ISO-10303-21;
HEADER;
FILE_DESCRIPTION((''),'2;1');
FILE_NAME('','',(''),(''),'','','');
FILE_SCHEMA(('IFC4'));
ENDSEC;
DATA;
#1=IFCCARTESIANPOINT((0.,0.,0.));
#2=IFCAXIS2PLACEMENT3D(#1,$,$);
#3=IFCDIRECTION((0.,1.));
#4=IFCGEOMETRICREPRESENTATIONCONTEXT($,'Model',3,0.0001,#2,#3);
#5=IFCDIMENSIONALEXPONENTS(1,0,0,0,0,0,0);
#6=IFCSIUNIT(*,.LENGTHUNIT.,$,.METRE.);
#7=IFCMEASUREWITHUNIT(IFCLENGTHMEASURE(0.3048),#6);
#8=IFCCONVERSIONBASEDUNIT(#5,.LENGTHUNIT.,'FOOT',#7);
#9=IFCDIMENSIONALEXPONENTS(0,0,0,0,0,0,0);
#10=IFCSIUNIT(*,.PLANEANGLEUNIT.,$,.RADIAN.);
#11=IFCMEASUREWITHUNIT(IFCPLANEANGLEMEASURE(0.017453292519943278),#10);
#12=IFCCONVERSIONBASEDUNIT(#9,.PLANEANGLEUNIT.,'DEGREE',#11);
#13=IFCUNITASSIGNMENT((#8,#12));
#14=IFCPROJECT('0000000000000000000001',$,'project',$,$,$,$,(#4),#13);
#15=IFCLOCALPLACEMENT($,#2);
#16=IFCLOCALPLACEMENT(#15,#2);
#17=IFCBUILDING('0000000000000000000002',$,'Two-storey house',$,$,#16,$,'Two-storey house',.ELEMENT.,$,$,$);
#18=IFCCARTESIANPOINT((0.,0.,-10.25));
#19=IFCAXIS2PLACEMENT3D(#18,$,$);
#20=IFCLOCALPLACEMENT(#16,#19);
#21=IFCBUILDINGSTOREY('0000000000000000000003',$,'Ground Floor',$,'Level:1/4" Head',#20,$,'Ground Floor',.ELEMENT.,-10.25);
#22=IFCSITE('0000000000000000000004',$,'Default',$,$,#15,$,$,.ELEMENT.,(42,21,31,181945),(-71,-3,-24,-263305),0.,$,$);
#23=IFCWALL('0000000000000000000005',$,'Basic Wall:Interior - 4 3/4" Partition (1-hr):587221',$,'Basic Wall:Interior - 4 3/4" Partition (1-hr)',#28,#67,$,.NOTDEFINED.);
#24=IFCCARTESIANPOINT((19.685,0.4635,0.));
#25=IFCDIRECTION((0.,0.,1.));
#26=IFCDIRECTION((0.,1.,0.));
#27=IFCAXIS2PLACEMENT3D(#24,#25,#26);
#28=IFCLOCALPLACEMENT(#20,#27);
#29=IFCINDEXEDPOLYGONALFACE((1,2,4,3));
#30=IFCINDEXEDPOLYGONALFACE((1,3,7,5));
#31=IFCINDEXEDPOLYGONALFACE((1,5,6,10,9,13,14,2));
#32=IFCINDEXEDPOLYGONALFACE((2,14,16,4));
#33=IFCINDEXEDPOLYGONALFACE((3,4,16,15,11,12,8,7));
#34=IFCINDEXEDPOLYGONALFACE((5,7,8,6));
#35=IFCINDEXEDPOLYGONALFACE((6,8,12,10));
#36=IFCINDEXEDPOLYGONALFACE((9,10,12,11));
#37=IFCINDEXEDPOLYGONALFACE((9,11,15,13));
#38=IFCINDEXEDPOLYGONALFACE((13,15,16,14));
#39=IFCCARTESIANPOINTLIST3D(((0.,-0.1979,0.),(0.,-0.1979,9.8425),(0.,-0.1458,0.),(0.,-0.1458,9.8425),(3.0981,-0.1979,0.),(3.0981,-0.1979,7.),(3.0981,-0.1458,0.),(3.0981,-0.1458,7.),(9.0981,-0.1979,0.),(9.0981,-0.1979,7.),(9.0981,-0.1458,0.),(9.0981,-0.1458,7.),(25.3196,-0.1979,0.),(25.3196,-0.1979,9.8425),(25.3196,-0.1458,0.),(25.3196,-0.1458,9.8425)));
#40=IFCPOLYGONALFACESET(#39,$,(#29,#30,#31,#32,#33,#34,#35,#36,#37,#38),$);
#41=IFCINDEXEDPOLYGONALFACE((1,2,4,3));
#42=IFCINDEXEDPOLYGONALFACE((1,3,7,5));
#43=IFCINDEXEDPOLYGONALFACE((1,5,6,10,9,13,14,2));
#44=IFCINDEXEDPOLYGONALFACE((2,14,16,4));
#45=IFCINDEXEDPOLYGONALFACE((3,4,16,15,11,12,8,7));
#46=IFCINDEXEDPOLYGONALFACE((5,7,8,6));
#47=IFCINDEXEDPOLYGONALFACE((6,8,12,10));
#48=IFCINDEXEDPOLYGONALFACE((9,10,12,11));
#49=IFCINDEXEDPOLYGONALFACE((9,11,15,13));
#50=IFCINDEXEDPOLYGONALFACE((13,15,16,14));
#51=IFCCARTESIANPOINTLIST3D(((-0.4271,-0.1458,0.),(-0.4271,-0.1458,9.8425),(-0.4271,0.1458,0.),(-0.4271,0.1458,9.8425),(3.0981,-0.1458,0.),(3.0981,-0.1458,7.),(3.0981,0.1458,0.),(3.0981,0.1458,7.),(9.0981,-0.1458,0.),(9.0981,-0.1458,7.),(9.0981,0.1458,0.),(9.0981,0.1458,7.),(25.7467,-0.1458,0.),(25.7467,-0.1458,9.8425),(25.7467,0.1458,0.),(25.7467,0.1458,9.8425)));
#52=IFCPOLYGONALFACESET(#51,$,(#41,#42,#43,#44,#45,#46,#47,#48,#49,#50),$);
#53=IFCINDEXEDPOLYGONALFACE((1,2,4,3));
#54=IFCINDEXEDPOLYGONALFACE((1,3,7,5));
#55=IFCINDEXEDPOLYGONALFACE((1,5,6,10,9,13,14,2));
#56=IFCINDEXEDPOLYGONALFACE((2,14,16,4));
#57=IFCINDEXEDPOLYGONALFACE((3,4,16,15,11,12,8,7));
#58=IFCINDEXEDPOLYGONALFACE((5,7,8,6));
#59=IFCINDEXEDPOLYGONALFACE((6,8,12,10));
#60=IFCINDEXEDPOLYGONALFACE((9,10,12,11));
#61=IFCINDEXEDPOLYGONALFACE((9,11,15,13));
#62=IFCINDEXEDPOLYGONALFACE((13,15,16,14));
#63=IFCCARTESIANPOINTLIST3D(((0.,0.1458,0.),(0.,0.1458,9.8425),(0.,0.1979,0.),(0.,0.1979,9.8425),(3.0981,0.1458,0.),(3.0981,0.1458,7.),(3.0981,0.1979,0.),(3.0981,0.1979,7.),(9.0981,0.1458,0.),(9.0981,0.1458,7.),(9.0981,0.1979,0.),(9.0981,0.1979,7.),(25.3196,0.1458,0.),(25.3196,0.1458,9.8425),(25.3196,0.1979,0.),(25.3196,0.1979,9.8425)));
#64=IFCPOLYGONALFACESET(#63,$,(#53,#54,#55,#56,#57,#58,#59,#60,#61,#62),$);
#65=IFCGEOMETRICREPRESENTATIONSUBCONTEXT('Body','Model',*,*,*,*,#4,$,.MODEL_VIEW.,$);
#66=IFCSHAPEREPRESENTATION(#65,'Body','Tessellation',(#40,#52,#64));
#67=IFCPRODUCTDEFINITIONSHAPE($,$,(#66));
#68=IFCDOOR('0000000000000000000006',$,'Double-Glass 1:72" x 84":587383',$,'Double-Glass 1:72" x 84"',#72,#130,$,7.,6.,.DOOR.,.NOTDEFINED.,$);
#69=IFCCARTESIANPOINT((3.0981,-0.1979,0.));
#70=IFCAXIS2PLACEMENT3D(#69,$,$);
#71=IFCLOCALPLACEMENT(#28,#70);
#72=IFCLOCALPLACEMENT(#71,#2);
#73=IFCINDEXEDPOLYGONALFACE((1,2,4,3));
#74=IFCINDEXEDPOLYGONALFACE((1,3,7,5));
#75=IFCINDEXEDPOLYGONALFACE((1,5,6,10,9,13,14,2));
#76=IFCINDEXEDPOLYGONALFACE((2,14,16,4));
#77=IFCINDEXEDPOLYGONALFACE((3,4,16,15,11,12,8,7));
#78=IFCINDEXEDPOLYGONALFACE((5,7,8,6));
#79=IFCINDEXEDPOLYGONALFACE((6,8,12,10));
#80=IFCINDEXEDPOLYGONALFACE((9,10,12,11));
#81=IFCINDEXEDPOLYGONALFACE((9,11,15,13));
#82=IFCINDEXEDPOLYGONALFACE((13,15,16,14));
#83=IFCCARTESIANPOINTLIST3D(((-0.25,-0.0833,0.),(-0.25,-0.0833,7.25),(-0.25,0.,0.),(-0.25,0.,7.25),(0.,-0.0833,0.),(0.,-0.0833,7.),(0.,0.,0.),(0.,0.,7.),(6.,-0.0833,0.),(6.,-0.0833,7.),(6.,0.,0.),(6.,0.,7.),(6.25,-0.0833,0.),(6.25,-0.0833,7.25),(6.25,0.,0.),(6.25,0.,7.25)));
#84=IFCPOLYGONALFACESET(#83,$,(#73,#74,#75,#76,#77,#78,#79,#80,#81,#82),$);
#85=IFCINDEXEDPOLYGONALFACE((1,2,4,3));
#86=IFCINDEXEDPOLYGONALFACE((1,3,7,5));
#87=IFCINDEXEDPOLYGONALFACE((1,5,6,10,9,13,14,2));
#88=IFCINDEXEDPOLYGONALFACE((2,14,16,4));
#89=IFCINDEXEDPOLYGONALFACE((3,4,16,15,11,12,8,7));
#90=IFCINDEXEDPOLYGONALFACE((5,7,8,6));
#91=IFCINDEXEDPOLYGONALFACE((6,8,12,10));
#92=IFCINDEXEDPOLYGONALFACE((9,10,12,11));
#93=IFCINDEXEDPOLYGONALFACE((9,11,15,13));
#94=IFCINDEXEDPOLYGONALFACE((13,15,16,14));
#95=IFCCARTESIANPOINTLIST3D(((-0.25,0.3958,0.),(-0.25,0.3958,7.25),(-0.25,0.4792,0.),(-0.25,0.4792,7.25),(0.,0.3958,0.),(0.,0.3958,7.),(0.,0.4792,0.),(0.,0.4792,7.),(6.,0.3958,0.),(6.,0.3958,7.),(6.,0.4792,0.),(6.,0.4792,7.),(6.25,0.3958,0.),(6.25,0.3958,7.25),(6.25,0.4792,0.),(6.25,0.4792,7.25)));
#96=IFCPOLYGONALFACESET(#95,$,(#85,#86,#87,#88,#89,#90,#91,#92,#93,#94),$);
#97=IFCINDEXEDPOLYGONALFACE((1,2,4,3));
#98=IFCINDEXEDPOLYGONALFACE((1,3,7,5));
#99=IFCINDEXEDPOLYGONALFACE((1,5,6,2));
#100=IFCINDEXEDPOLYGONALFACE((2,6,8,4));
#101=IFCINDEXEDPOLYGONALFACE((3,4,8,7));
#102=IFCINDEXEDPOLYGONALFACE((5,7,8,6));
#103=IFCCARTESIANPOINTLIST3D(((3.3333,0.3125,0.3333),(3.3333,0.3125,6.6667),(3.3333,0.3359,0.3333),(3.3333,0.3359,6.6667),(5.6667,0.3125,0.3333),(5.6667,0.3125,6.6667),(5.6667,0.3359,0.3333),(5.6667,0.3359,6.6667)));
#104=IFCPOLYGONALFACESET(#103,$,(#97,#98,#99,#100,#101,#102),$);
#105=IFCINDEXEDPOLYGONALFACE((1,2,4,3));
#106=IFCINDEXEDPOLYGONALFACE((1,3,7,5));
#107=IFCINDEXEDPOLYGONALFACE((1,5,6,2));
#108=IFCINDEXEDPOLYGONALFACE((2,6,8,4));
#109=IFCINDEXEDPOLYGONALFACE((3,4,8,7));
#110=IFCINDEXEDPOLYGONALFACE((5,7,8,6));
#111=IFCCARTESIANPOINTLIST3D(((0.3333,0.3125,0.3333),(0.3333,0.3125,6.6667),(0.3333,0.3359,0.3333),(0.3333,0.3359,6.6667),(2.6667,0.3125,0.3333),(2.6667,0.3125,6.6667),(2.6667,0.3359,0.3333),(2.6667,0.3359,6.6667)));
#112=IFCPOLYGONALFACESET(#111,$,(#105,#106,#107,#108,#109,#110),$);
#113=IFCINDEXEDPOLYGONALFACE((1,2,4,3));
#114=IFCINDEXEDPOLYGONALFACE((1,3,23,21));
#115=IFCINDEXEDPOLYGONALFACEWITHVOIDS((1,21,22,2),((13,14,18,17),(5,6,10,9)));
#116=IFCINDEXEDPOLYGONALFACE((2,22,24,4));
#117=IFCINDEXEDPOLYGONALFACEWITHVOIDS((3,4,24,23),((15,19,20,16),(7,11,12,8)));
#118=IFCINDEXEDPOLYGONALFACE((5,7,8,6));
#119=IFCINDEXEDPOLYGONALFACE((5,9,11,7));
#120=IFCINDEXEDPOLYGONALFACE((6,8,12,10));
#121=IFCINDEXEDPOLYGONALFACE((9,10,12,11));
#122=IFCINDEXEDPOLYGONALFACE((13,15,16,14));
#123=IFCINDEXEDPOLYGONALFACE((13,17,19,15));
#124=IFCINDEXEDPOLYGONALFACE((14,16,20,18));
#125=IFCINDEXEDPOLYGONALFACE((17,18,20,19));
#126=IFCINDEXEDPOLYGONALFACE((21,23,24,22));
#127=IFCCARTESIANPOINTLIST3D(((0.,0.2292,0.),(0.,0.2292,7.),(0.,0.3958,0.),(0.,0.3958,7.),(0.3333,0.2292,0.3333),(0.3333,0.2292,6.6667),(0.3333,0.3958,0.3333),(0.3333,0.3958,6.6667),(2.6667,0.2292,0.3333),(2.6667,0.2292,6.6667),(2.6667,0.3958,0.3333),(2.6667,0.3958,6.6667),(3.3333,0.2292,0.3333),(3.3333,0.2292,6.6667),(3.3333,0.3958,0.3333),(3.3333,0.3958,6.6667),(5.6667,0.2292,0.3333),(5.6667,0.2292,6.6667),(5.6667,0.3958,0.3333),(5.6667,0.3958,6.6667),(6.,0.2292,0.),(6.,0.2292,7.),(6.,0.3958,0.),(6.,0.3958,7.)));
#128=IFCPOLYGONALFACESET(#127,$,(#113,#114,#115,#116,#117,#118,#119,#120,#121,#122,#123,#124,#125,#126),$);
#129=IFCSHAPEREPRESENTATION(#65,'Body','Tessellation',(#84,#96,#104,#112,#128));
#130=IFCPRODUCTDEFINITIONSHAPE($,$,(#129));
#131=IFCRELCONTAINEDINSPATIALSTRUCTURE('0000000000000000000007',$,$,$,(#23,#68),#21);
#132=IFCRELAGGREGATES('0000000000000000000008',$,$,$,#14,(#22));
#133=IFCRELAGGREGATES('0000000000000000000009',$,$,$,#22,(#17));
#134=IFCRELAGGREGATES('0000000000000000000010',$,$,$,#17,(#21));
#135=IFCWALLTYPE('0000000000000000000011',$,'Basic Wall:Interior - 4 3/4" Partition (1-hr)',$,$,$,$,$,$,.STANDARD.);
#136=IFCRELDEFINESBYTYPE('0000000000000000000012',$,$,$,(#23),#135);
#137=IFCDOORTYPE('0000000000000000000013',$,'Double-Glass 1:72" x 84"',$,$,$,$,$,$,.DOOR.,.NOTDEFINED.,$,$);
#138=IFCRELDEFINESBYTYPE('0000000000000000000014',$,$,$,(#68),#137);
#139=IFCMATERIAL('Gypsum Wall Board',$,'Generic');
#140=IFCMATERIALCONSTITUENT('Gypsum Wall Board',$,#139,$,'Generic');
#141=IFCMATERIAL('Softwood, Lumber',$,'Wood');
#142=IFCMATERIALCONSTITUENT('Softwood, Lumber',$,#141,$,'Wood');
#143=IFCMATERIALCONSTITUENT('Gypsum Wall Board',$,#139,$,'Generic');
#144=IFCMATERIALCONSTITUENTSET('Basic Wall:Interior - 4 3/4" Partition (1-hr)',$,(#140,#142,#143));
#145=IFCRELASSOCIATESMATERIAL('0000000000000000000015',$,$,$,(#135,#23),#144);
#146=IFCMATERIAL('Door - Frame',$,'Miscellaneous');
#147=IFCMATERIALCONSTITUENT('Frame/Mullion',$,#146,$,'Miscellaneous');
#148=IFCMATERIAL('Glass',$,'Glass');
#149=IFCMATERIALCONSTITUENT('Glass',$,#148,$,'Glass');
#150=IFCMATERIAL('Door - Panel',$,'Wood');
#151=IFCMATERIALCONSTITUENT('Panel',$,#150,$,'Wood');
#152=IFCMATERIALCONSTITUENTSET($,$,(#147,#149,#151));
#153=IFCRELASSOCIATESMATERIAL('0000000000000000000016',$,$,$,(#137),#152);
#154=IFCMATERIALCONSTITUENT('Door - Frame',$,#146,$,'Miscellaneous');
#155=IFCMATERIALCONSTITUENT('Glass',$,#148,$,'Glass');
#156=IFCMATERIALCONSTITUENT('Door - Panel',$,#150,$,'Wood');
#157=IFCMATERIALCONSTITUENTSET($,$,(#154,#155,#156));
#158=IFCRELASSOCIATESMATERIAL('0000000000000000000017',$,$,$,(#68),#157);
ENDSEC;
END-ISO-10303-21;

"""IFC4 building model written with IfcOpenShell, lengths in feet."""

from ifc_helpers import new_model, entity, si_unit, converted_unit, direction, frame, origin, place, context, subcontext, project, spatial, indexed_curve, outline, extrude, source, transform, mapped, material, constituent, constituent_set, type_object, type_shapes, element, fill, save


model = new_model("IFC4")

# Units and contexts
model_context = context("Model", 3, precision=0.0001, world=origin(), true_north=direction((0.0, 1.0)))
body_context = subcontext(model_context, "Body", "Model", "MODEL_VIEW")
ifc_project = project(units=[converted_unit("LENGTHUNIT", "FOOT", entity("IfcLengthMeasure", 0.3048), si_unit("LENGTHUNIT", "METRE"), dimensions=[1, 0, 0, 0, 0, 0, 0]), converted_unit("PLANEANGLEUNIT", "DEGREE", entity("IfcPlaneAngleMeasure", 0.017453292519943278), si_unit("PLANEANGLEUNIT", "RADIAN"), dimensions=[0, 0, 0, 0, 0, 0, 0])], contexts=[model_context])

# Site, building, storey
site_placement = place(None, origin())
site = spatial("IfcSite", under=ifc_project, at=site_placement, Name="Default", CompositionType="ELEMENT", RefLatitude=(42, 21, 31, 181945), RefLongitude=(-71, -3, -24, -263305), RefElevation=0.0)
building_placement = place(site_placement, origin())
building = spatial("IfcBuilding", under=site, at=building_placement, Name="Two-storey house", LongName="Two-storey house", CompositionType="ELEMENT")
storey_placement = place(building_placement, frame((0.0, 0.0, -10.25)))
storey = spatial("IfcBuildingStorey", under=building, at=storey_placement, Name="Ground Floor", ObjectType="Level:1/4\" Head", LongName="Ground Floor", CompositionType="ELEMENT", Elevation=-10.25)

# Shared definitions
ifc_material_1 = material(Name="Softwood, Lumber", Category="Wood")
ifc_material_2 = material(Name="Gypsum Wall Board", Category="Generic")
ifc_material_3 = material(Name="Door - Frame", Category="Miscellaneous")
ifc_material_4 = material(Name="Glass", Category="Glass")
ifc_material_5 = material(Name="Door - Panel", Category="Wood")

# Wall, opening, door
ifc_constituent_1 = constituent(ifc_material_2, Name="Gypsum Wall Board", Category="Generic")
ifc_constituent_2 = constituent(ifc_material_1, Name="Softwood, Lumber", Category="Wood")
ifc_constituent_3 = constituent(ifc_material_2, Name="Gypsum Wall Board", Category="Generic")
ifc_constituent_set_1 = constituent_set(constituents=[ifc_constituent_1, ifc_constituent_2, ifc_constituent_3], Name="Basic Wall:Interior - 4 3/4\" Partition (1-hr)")
wall_type_1 = type_object("IfcWallType", Name="Basic Wall:Interior - 4 3/4\" Partition (1-hr)", PredefinedType="STANDARD", material=ifc_constituent_set_1)
wall_1_placement = place(storey_placement, frame((19.685, 0.4635, 0.0), z_axis=(0.0, 0.0, 1.0), x_axis=(0.0, 1.0, 0.0)))
wall_1 = element("IfcWall", 1, at=wall_1_placement, inside=storey, type_object=wall_type_1, material=ifc_constituent_set_1, Name="Basic Wall:Interior - 4 3/4\" Partition (1-hr):587221", ObjectType="Basic Wall:Interior - 4 3/4\" Partition (1-hr)", PredefinedType="NOTDEFINED", context=body_context, shape_type="SweptSolid", body=[
    extrude(outline(indexed_curve([(-4.2106, -6.2808), (-4.2106, -9.379), (5.6319, -9.379), (5.6319, 15.9407), (-4.2106, 15.9407), (-4.2106, -0.2808), (2.7894, -0.2808), (2.7894, -6.2808), (-4.2106, -6.2808)], self_intersect=False)), frame((9.379, -0.1458, 4.2106), z_axis=(0.0, 1.0, 0.0), x_axis=(0.0, 0.0, 1.0)), (0.0, 0.0, -1.0), 0.0521),
    extrude(outline(indexed_curve([(-4.2106, -6.2808), (-4.2106, -9.8061), (5.6319, -9.8061), (5.6319, 16.3677), (-4.2106, 16.3677), (-4.2106, -0.2808), (2.7894, -0.2808), (2.7894, -6.2808), (-4.2106, -6.2808)], self_intersect=False)), frame((9.379, 0.1458, 4.2106), z_axis=(0.0, 1.0, 0.0), x_axis=(0.0, 0.0, 1.0)), (0.0, 0.0, -1.0), 0.2917),
    extrude(outline(indexed_curve([(-4.2106, -15.9407), (5.6319, -15.9407), (5.6319, 9.379), (-4.2106, 9.379), (-4.2106, 6.2808), (2.7894, 6.2808), (2.7894, 0.2808), (-4.2106, 0.2808), (-4.2106, -15.9407)], self_intersect=False)), frame((9.379, 0.1979, 4.2106), z_axis=(0.0, -1.0, 0.0), x_axis=(0.0, 0.0, 1.0)), (0.0, 0.0, 1.0), 0.0521),
])
opening_1_placement = place(wall_1_placement, frame((3.0981, -0.1979, 0.0)))
opening_1 = element("IfcOpeningElement", 2, at=opening_1_placement, cuts=wall_1, PredefinedType="OPENING", context=body_context, shape_type="SweptSolid", body=[
    extrude(outline(indexed_curve([(0.0, 0.0), (7.0, 0.0), (7.0, 6.0), (0.0, 6.0), (0.0, 0.0)], self_intersect=False)), frame((0.0, 0.0, 0.0), z_axis=(0.0, 1.0, 0.0), x_axis=(0.0, 0.0, 1.0)), (0.0, 0.0, 1.0), 0.3958),
])
ifc_constituent_4 = constituent(ifc_material_3, Name="Door - Frame", Category="Miscellaneous")
ifc_constituent_5 = constituent(ifc_material_4, Name="Glass", Category="Glass")
ifc_constituent_6 = constituent(ifc_material_5, Name="Door - Panel", Category="Wood")
ifc_constituent_set_2 = constituent_set(constituents=[ifc_constituent_4, ifc_constituent_5, ifc_constituent_6])
ifc_constituent_7 = constituent(ifc_material_3, Name="Frame/Mullion", Category="Miscellaneous")
ifc_constituent_8 = constituent(ifc_material_4, Name="Glass", Category="Glass")
ifc_constituent_9 = constituent(ifc_material_5, Name="Panel", Category="Wood")
ifc_constituent_set_3 = constituent_set(constituents=[ifc_constituent_7, ifc_constituent_8, ifc_constituent_9])
door_type_1 = type_object("IfcDoorType", Name="Double-Glass 1:72\" x 84\"", OperationType="NOTDEFINED", PredefinedType="DOOR", material=ifc_constituent_set_3)
shared_shape_1 = source(origin(), body_context, "Body", "SweptSolid", [
    extrude(outline(indexed_curve([(-3.25, -3.5625), (-3.0, -3.5625), (-3.0, 3.4375), (3.0, 3.4375), (3.0, -3.5625), (3.25, -3.5625), (3.25, 3.6875), (-3.25, 3.6875), (-3.25, -3.5625)], self_intersect=False)), frame((3.0, -0.0833, 3.5625), z_axis=(0.0, 1.0, 0.0), x_axis=(-1.0, 0.0, 0.0)), (0.0, 0.0, 1.0), 0.0833),
    extrude(outline(indexed_curve([(-3.0, -3.4375), (-3.0, 3.5625), (-3.25, 3.5625), (-3.25, -3.6875), (3.25, -3.6875), (3.25, 3.5625), (3.0, 3.5625), (3.0, -3.4375), (-3.0, -3.4375)], self_intersect=False)), frame((3.0, 0.3958, 3.5625), z_axis=(0.0, -1.0, 0.0), x_axis=(-1.0, 0.0, 0.0)), (0.0, 0.0, -1.0), 0.0833),
    extrude(outline(indexed_curve([(-0.0117, -1.1667), (0.0117, -1.1667), (0.0117, 1.1667), (-0.0117, 1.1667), (-0.0117, -1.1667)], self_intersect=False)), frame((4.5, 0.3242, 0.3333), z_axis=(0.0, 0.0, 1.0), x_axis=(0.0, 1.0, 0.0)), (0.0, 0.0, 1.0), 6.3333),
    extrude(outline(indexed_curve([(-0.0117, -1.1667), (0.0117, -1.1667), (0.0117, 1.1667), (-0.0117, 1.1667), (-0.0117, -1.1667)], self_intersect=False)), frame((1.5, 0.3242, 0.3333), z_axis=(0.0, 0.0, 1.0), x_axis=(0.0, 1.0, 0.0)), (0.0, 0.0, 1.0), 6.3333),
    extrude(outline(indexed_curve([(-3.5, -3.0), (3.5, -3.0), (3.5, 3.0), (-3.5, 3.0), (-3.5, -3.0)], self_intersect=False), holes=[indexed_curve([(-3.1667, 0.3333), (-3.1667, 2.6667), (3.1667, 2.6667), (3.1667, 0.3333), (-3.1667, 0.3333)], self_intersect=False), indexed_curve([(-3.1667, -2.6667), (-3.1667, -0.3333), (3.1667, -0.3333), (3.1667, -2.6667), (-3.1667, -2.6667)], self_intersect=False)]), frame((3.0, 0.2292, 3.5), z_axis=(0.0, 1.0, 0.0), x_axis=(0.0, 0.0, -1.0)), (0.0, 0.0, 1.0), 0.1667),
])
type_shapes(door_type_1, [shared_shape_1])
door_1_placement = place(opening_1_placement, origin())
door_1 = element("IfcDoor", 3, at=door_1_placement, inside=storey, type_object=door_type_1, material=ifc_constituent_set_2, Name="Double-Glass 1:72\" x 84\":587383", ObjectType="Double-Glass 1:72\" x 84\"", OperationType="NOTDEFINED", OverallHeight=7.0, OverallWidth=6.0, PredefinedType="DOOR", context=body_context, shape_type="MappedRepresentation", body=[
    mapped(shared_shape_1, transform((0.0, 0.0, 0.0), scale=1.0)),
])
fill(opening_1, door_1)

save(model, "model.ifc")
